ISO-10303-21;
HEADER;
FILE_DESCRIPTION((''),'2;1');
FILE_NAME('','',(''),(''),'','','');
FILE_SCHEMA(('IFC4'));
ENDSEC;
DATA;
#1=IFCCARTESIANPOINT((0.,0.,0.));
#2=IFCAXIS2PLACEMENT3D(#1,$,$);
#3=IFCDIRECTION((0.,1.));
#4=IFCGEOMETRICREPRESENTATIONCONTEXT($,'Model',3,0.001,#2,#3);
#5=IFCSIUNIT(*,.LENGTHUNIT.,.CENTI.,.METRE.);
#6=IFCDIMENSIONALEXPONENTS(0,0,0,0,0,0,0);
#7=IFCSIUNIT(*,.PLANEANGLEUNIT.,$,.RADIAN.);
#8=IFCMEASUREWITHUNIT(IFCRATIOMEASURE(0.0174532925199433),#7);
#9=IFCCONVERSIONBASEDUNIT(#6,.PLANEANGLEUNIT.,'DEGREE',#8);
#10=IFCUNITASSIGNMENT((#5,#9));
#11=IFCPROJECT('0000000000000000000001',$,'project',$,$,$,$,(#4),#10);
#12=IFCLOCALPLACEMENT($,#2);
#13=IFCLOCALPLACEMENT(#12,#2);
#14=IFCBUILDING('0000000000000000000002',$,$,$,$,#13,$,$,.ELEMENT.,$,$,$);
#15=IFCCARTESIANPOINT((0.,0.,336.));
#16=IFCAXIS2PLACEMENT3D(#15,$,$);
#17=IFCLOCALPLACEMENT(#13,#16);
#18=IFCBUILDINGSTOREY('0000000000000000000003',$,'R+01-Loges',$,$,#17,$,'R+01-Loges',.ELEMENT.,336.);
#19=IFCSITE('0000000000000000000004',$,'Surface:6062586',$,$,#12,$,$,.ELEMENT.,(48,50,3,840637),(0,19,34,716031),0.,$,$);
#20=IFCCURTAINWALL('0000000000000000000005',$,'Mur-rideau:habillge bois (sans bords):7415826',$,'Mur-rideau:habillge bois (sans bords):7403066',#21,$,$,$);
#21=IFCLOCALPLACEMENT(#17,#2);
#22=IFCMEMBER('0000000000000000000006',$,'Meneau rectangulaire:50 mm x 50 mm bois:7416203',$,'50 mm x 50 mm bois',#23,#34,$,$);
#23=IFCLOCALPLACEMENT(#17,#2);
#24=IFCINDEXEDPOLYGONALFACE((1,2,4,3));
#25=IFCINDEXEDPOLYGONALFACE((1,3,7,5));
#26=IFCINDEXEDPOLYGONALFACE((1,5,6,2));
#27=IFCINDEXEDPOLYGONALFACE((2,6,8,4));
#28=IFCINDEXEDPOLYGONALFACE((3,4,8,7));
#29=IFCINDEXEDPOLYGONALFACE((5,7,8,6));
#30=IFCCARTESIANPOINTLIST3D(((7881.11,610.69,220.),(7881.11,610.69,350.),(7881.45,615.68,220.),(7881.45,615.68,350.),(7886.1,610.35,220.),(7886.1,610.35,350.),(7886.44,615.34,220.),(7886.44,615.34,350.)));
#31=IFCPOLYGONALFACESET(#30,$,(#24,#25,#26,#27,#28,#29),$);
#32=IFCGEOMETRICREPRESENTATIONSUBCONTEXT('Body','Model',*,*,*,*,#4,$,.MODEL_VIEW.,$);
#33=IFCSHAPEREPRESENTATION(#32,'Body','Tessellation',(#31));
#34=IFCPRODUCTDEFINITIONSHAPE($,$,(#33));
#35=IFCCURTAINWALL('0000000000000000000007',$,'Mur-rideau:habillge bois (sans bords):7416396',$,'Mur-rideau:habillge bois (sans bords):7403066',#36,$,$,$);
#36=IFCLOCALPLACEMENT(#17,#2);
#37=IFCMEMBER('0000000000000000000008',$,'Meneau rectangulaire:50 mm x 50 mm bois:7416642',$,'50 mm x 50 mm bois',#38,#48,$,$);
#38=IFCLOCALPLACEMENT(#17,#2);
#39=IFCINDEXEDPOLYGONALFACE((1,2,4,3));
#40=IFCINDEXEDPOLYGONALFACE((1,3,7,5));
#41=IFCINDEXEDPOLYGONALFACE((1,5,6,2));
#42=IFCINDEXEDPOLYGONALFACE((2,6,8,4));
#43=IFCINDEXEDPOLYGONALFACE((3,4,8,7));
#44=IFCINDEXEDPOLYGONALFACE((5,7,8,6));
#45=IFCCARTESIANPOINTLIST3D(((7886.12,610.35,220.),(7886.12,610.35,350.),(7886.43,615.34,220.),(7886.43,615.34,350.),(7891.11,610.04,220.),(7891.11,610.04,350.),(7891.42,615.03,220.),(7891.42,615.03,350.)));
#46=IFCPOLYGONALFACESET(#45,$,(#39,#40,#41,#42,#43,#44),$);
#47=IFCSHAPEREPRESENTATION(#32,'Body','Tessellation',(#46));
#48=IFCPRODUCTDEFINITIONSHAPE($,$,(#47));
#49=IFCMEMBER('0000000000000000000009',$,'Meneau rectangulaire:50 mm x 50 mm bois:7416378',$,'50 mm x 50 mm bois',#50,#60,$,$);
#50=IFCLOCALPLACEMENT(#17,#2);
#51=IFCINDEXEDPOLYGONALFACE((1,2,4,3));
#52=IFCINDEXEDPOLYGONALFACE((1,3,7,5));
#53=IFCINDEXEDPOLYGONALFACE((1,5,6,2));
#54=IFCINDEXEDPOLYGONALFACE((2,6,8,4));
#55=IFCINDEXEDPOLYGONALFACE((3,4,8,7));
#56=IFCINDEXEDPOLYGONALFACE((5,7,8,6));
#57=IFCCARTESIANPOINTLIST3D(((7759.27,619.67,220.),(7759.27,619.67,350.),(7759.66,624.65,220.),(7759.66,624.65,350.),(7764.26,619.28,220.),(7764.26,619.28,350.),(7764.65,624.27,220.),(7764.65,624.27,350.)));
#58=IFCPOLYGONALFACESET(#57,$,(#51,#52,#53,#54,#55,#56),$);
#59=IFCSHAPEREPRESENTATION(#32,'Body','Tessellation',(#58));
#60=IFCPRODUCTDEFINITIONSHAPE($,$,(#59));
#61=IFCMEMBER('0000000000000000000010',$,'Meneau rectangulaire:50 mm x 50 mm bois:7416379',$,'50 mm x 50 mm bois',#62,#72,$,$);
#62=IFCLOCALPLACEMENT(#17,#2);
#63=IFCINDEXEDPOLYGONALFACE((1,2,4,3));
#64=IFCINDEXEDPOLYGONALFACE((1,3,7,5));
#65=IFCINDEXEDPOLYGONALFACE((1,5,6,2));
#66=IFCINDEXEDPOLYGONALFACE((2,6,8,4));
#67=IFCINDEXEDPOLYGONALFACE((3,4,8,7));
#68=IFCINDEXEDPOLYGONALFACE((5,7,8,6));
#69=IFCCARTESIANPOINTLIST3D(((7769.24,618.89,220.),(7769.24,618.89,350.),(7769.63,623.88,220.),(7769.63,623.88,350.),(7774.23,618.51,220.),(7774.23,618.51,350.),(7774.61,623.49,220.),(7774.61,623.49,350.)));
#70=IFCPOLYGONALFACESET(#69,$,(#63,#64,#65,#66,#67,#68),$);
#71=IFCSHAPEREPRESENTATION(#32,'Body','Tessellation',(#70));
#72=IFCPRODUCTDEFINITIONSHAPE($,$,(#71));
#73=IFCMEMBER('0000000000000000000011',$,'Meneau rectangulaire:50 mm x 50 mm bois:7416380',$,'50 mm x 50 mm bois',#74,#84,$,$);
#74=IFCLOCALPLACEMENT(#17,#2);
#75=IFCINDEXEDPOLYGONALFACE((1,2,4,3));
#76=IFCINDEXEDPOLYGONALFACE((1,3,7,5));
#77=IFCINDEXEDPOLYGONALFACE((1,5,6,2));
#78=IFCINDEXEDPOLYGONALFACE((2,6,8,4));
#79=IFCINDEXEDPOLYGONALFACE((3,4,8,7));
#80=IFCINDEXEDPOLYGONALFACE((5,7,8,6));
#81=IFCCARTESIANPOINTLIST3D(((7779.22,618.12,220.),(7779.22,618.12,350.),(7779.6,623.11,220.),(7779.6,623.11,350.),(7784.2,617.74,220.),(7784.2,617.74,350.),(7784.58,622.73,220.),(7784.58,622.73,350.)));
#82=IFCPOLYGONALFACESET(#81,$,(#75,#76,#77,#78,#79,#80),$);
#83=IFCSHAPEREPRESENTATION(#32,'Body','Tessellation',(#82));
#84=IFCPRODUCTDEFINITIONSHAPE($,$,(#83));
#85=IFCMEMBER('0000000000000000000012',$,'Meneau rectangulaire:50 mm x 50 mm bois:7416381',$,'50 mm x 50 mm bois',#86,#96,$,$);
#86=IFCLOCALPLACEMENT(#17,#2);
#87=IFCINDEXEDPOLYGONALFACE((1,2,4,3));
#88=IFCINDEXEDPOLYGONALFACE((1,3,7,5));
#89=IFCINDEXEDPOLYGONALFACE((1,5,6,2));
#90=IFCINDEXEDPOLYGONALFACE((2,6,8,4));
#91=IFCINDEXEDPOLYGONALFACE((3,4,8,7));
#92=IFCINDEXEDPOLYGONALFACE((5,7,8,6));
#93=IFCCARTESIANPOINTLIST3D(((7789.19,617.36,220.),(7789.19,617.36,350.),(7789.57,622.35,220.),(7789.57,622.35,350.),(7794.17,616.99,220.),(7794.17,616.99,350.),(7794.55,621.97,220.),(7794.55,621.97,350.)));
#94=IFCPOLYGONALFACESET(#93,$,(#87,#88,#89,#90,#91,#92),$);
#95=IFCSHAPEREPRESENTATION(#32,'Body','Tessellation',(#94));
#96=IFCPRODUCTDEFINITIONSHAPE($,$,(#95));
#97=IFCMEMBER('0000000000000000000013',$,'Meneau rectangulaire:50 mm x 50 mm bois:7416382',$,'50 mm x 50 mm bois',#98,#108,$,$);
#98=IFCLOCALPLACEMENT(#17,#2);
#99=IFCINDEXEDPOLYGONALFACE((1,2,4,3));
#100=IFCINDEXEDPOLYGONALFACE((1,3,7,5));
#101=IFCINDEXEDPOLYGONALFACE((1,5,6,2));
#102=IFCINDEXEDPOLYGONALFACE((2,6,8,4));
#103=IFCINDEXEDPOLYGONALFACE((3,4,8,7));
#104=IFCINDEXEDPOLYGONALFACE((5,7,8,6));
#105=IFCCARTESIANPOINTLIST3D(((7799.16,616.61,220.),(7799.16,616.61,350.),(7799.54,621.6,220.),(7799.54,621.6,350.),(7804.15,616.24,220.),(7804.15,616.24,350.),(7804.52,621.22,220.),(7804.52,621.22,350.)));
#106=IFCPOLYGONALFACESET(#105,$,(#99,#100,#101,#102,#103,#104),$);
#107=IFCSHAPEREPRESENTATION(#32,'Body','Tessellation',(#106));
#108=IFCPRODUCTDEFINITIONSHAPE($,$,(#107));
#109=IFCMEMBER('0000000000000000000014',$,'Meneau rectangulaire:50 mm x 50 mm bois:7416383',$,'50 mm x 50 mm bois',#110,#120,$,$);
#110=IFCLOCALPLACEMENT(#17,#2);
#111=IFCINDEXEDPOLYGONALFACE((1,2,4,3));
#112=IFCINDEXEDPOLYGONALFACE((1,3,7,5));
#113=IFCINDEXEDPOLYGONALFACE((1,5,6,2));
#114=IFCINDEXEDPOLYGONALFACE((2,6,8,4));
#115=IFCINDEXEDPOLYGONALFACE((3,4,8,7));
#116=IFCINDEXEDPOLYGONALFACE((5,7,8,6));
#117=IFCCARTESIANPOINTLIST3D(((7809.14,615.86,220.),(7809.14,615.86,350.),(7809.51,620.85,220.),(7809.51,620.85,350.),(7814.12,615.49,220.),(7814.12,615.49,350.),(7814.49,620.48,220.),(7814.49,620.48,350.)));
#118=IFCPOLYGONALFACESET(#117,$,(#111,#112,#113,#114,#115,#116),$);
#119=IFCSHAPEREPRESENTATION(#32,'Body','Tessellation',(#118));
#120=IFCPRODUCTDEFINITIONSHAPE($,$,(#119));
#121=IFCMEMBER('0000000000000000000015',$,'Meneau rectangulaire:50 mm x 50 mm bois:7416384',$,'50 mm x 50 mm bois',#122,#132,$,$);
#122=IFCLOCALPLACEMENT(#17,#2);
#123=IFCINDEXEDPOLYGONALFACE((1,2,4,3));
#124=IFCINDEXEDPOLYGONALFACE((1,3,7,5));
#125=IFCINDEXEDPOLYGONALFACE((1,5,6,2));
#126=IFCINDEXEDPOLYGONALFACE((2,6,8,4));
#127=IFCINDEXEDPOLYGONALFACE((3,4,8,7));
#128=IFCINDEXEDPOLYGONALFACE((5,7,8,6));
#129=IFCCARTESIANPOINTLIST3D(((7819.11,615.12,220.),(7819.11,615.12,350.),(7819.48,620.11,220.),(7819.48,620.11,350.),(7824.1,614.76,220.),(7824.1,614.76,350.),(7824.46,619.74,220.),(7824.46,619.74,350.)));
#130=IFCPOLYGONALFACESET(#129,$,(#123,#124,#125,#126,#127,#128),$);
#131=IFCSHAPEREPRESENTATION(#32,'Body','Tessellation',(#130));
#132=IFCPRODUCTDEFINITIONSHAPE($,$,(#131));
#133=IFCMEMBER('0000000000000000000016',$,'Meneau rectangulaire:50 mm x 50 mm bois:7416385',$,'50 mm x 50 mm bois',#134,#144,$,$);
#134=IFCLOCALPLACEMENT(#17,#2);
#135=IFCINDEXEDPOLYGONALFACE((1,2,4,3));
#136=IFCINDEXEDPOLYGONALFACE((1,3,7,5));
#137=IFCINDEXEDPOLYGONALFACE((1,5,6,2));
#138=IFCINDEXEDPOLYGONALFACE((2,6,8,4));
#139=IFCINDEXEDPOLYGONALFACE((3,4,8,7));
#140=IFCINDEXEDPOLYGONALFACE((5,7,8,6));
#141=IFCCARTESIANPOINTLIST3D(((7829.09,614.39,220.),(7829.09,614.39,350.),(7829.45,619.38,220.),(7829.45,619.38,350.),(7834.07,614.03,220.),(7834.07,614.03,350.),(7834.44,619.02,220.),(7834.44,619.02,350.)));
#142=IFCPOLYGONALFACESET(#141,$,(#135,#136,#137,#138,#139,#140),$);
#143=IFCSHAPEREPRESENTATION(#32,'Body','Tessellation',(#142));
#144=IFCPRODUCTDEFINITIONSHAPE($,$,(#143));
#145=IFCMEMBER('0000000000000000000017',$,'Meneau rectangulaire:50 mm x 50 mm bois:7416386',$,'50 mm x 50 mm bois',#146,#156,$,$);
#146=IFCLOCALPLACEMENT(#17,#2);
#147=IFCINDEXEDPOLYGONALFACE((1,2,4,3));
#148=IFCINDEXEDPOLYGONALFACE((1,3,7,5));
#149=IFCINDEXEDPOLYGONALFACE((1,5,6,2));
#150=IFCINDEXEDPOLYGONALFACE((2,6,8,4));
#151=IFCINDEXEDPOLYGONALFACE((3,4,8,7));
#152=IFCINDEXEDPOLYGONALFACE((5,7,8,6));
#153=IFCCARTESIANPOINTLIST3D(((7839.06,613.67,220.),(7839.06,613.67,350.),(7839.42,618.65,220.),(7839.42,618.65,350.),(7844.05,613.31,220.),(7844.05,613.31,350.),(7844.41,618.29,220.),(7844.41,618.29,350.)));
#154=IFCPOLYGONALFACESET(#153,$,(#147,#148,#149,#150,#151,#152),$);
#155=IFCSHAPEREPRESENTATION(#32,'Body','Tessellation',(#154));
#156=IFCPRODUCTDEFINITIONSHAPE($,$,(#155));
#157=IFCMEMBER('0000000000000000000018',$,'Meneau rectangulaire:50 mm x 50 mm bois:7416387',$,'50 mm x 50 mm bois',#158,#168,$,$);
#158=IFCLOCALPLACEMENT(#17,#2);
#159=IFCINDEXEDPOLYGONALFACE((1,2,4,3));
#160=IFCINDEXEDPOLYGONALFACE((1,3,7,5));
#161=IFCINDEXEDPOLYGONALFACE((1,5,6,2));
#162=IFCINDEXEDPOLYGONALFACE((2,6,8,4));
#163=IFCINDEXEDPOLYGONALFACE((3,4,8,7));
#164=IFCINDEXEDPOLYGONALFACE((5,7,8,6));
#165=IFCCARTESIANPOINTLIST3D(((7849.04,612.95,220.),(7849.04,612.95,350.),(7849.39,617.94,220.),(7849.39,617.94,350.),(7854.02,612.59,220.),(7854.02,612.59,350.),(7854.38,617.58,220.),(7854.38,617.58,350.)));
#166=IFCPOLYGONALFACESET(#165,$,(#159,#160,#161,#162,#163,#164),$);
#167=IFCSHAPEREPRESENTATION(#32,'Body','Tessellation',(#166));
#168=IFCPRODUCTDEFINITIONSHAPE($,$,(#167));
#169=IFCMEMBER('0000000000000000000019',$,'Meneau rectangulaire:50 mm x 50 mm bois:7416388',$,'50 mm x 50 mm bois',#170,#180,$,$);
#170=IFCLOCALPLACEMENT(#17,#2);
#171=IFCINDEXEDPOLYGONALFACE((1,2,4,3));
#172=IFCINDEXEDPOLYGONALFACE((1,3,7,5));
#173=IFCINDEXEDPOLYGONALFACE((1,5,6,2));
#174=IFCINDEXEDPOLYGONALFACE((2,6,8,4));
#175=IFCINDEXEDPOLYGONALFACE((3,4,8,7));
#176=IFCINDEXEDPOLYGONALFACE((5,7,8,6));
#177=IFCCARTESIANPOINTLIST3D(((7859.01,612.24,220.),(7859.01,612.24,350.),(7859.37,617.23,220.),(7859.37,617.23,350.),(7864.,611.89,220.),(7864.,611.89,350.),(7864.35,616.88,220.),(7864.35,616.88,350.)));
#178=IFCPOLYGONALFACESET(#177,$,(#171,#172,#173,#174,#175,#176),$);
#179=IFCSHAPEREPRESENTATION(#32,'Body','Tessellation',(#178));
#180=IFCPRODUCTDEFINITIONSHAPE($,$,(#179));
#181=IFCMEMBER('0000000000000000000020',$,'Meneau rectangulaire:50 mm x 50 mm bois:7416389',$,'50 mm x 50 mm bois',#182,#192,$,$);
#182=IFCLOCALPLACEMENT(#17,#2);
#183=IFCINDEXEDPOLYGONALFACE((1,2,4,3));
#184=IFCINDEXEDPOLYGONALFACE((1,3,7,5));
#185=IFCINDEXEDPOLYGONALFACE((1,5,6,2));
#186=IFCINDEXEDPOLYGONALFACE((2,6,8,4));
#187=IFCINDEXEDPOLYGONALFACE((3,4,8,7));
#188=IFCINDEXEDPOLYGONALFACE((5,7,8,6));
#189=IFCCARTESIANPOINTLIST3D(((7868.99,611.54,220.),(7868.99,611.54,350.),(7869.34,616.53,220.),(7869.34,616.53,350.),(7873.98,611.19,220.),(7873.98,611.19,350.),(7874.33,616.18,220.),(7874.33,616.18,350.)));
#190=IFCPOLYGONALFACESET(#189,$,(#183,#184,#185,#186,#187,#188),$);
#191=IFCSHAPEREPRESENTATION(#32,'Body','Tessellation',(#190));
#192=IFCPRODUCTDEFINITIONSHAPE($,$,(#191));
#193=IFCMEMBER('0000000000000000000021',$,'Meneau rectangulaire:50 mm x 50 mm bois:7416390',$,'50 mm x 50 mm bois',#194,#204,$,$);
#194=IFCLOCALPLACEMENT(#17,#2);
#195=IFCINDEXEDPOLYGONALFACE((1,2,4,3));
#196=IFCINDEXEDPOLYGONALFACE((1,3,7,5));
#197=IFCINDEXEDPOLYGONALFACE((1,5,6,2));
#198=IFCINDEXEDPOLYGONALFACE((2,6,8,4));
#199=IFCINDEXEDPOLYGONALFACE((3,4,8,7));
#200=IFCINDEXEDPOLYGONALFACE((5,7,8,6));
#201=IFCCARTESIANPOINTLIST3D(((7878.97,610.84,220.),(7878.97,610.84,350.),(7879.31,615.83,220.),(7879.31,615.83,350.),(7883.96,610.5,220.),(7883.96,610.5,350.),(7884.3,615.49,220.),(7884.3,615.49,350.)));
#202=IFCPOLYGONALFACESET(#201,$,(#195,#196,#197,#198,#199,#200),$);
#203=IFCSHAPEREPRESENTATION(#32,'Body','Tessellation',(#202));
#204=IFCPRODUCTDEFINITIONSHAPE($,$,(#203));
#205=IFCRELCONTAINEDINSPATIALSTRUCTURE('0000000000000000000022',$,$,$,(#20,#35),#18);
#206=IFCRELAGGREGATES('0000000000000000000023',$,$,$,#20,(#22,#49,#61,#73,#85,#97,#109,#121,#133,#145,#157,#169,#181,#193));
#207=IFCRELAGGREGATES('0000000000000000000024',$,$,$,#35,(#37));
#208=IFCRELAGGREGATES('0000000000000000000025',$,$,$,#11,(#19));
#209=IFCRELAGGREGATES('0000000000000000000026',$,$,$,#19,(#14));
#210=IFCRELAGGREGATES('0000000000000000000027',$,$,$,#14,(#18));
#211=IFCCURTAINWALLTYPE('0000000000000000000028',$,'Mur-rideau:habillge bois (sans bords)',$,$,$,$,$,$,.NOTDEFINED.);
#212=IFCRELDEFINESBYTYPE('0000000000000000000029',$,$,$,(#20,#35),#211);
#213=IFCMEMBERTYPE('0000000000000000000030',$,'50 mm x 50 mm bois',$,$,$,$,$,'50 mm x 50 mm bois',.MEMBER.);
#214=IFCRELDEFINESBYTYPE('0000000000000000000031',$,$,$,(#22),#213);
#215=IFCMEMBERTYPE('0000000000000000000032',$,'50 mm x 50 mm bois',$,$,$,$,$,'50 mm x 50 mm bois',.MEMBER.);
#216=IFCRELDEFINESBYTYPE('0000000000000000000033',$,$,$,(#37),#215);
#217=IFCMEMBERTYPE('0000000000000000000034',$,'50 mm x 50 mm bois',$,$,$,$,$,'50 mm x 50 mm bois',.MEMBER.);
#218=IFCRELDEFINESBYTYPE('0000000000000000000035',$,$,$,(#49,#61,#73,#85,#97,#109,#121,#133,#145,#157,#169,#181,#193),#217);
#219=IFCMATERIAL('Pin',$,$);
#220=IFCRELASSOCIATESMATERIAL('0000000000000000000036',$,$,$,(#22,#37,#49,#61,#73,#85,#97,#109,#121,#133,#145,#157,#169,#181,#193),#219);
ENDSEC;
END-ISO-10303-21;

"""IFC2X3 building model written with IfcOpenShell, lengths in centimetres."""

from ifc_helpers import new_model, entity, si_unit, converted_unit, direction, frame, origin, origin_2d_with_axis, place, context, subcontext, project, spatial, rectangle, extrude, source, transform, mapped, material, type_object, type_shapes, element, aggregate, save


model = new_model("IFC2X3")

# Units and contexts
model_context = context("Model", 3, precision=0.001, world=origin(), true_north=direction((0.0, 1.0)))
body_context = subcontext(model_context, "Body", "Model", "MODEL_VIEW")
ifc_project = project(units=[si_unit("LENGTHUNIT", "METRE", prefix="CENTI"), converted_unit("PLANEANGLEUNIT", "DEGREE", entity("IfcRatioMeasure", 0.0174532925199433), si_unit("PLANEANGLEUNIT", "RADIAN"), dimensions=[0, 0, 0, 0, 0, 0, 0])], contexts=[model_context])

# Site, building, storey
site_placement = place(None, origin())
site = spatial("IfcSite", under=ifc_project, at=site_placement, Name="Surface:6062586", CompositionType="ELEMENT", RefLatitude=(48, 50, 3, 840637), RefLongitude=(0, 19, 34, 716031), RefElevation=0.0)
building_placement = place(site_placement, origin())
building = spatial("IfcBuilding", under=site, at=building_placement, CompositionType="ELEMENT")
storey_placement = place(building_placement, frame((0.0, 0.0, 336.0)))
storey = spatial("IfcBuildingStorey", under=building, at=storey_placement, Name="R+01-Loges", LongName="R+01-Loges", CompositionType="ELEMENT", Elevation=336.0)

# Curtain walls, members
curtain_wall_type = type_object("IfcCurtainWallType", Name="Mur-rideau:habillge bois (sans bords)", PredefinedType="NOTDEFINED")
curtain_wall_1_placement = place(storey_placement, frame((0.0, 0.0, -336.0)))
curtain_wall_1 = element("IfcCurtainWall", 1, at=curtain_wall_1_placement, inside=storey, type_object=curtain_wall_type, Name="Mur-rideau:habillge bois (sans bords):7415826", ObjectType="Mur-rideau:habillge bois (sans bords):7403066")
ifc_material_1 = material(Name="Pin")
member_type_1 = type_object("IfcMemberType", Name="50 mm x 50 mm bois", ElementType="50 mm x 50 mm bois", PredefinedType="MEMBER")
shared_shape_1 = source(origin(), body_context, "Body", "SweptSolid", [
    extrude(rectangle(XDim=5.0, YDim=5.0, at=origin_2d_with_axis()), frame((-2.5, 0.0, -130.0), z_axis=(0.0, 0.0, 1.0), x_axis=(0.0, -1.0, 0.0)), (0.0, 0.0, 1.0), 130.0),
])
type_shapes(member_type_1, [shared_shape_1])
member_1_placement = place(storey_placement, frame((7886.27, 612.84, 220.0), z_axis=(0.0, 0.0, -1.0), x_axis=(0.997631, -0.068788, 0.0)))
member_1 = element("IfcMember", 2, at=member_1_placement, type_object=member_type_1, material=ifc_material_1, Name="Meneau rectangulaire:50 mm x 50 mm bois:7416203", ObjectType="50 mm x 50 mm bois", context=body_context, shape_type="MappedRepresentation", body=[
    mapped(shared_shape_1, transform((0.0, 0.0, 0.0), scale=1.0)),
])
curtain_wall_2_placement = place(storey_placement, frame((0.0, 0.0, -336.0)))
curtain_wall_2 = element("IfcCurtainWall", 3, at=curtain_wall_2_placement, inside=storey, type_object=curtain_wall_type, Name="Mur-rideau:habillge bois (sans bords):7416396", ObjectType="Mur-rideau:habillge bois (sans bords):7403066")
member_type_2 = type_object("IfcMemberType", Name="50 mm x 50 mm bois", ElementType="50 mm x 50 mm bois", PredefinedType="MEMBER")
shared_shape_2 = source(origin(), body_context, "Body", "SweptSolid", [
    extrude(rectangle(XDim=5.0, YDim=5.0, at=origin_2d_with_axis()), frame((-2.5, 0.0, -130.0), z_axis=(0.0, 0.0, 1.0), x_axis=(0.0, -1.0, 0.0)), (0.0, 0.0, 1.0), 130.0),
])
type_shapes(member_type_2, [shared_shape_2])
member_2_placement = place(storey_placement, frame((7886.27, 612.84, 350.0), z_axis=(0.0, 0.0, 1.0), x_axis=(-0.998061, 0.062237, 0.0)))
member_2 = element("IfcMember", 4, at=member_2_placement, type_object=member_type_2, material=ifc_material_1, Name="Meneau rectangulaire:50 mm x 50 mm bois:7416642", ObjectType="50 mm x 50 mm bois", context=body_context, shape_type="MappedRepresentation", body=[
    mapped(shared_shape_2, transform((0.0, 0.0, 0.0), scale=1.0)),
])

# Members
member_type_3 = type_object("IfcMemberType", Name="50 mm x 50 mm bois", ElementType="50 mm x 50 mm bois", PredefinedType="MEMBER")
shared_shape_3 = source(origin(), body_context, "Body", "SweptSolid", [
    extrude(rectangle(XDim=5.0, YDim=5.0, at=origin_2d_with_axis()), frame((0.0, 0.0, -130.0), z_axis=(0.0, 0.0, 1.0), x_axis=(0.0, -1.0, 0.0)), (0.0, 0.0, 1.0), 130.0),
])
type_shapes(member_type_3, [shared_shape_3])
member_3_placement = place(storey_placement, frame((7761.96, 621.97, 220.0), z_axis=(0.0, 0.0, -1.0), x_axis=(0.996972, -0.077764, 0.0)))
member_3 = element("IfcMember", 5, at=member_3_placement, type_object=member_type_3, material=ifc_material_1, Name="Meneau rectangulaire:50 mm x 50 mm bois:7416378", ObjectType="50 mm x 50 mm bois", context=body_context, shape_type="MappedRepresentation", body=[
    mapped(shared_shape_3, transform((0.0, 0.0, 0.0), scale=1.0)),
])
member_4_placement = place(storey_placement, frame((7771.93, 621.19, 220.0), z_axis=(0.0, 0.0, -1.0), x_axis=(0.997029, -0.077031, 0.0)))
member_4 = element("IfcMember", 6, at=member_4_placement, type_object=member_type_3, material=ifc_material_1, Name="Meneau rectangulaire:50 mm x 50 mm bois:7416379", ObjectType="50 mm x 50 mm bois", context=body_context, shape_type="MappedRepresentation", body=[
    mapped(shared_shape_3, transform((0.0, 0.0, 0.0), scale=1.0)),
])
member_5_placement = place(storey_placement, frame((7781.9, 620.43, 220.0), z_axis=(0.0, 0.0, -1.0), x_axis=(0.997085, -0.076297, 0.0)))
member_5 = element("IfcMember", 7, at=member_5_placement, type_object=member_type_3, material=ifc_material_1, Name="Meneau rectangulaire:50 mm x 50 mm bois:7416380", ObjectType="50 mm x 50 mm bois", context=body_context, shape_type="MappedRepresentation", body=[
    mapped(shared_shape_3, transform((0.0, 0.0, 0.0), scale=1.0)),
])
member_6_placement = place(storey_placement, frame((7791.87, 619.67, 220.0), z_axis=(0.0, 0.0, -1.0), x_axis=(0.997141, -0.075564, 0.0)))
member_6 = element("IfcMember", 8, at=member_6_placement, type_object=member_type_3, material=ifc_material_1, Name="Meneau rectangulaire:50 mm x 50 mm bois:7416381", ObjectType="50 mm x 50 mm bois", context=body_context, shape_type="MappedRepresentation", body=[
    mapped(shared_shape_3, transform((0.0, 0.0, 0.0), scale=1.0)),
])
member_7_placement = place(storey_placement, frame((7801.84, 618.92, 220.0), z_axis=(0.0, 0.0, -1.0), x_axis=(0.997196, -0.07483, 0.0)))
member_7 = element("IfcMember", 9, at=member_7_placement, type_object=member_type_3, material=ifc_material_1, Name="Meneau rectangulaire:50 mm x 50 mm bois:7416382", ObjectType="50 mm x 50 mm bois", context=body_context, shape_type="MappedRepresentation", body=[
    mapped(shared_shape_3, transform((0.0, 0.0, 0.0), scale=1.0)),
])
member_8_placement = place(storey_placement, frame((7811.81, 618.17, 220.0), z_axis=(0.0, 0.0, -1.0), x_axis=(0.997251, -0.074096, 0.0)))
member_8 = element("IfcMember", 10, at=member_8_placement, type_object=member_type_3, material=ifc_material_1, Name="Meneau rectangulaire:50 mm x 50 mm bois:7416383", ObjectType="50 mm x 50 mm bois", context=body_context, shape_type="MappedRepresentation", body=[
    mapped(shared_shape_3, transform((0.0, 0.0, 0.0), scale=1.0)),
])
member_9_placement = place(storey_placement, frame((7821.79, 617.43, 220.0), z_axis=(0.0, 0.0, -1.0), x_axis=(0.997305, -0.073362, 0.0)))
member_9 = element("IfcMember", 11, at=member_9_placement, type_object=member_type_3, material=ifc_material_1, Name="Meneau rectangulaire:50 mm x 50 mm bois:7416384", ObjectType="50 mm x 50 mm bois", context=body_context, shape_type="MappedRepresentation", body=[
    mapped(shared_shape_3, transform((0.0, 0.0, 0.0), scale=1.0)),
])
member_10_placement = place(storey_placement, frame((7831.76, 616.7, 220.0), z_axis=(0.0, 0.0, -1.0), x_axis=(0.997359, -0.072628, 0.0)))
member_10 = element("IfcMember", 12, at=member_10_placement, type_object=member_type_3, material=ifc_material_1, Name="Meneau rectangulaire:50 mm x 50 mm bois:7416385", ObjectType="50 mm x 50 mm bois", context=body_context, shape_type="MappedRepresentation", body=[
    mapped(shared_shape_3, transform((0.0, 0.0, 0.0), scale=1.0)),
])
member_11_placement = place(storey_placement, frame((7841.73, 615.98, 220.0), z_axis=(0.0, 0.0, -1.0), x_axis=(0.997412, -0.071895, 0.0)))
member_11 = element("IfcMember", 13, at=member_11_placement, type_object=member_type_3, material=ifc_material_1, Name="Meneau rectangulaire:50 mm x 50 mm bois:7416386", ObjectType="50 mm x 50 mm bois", context=body_context, shape_type="MappedRepresentation", body=[
    mapped(shared_shape_3, transform((0.0, 0.0, 0.0), scale=1.0)),
])
member_12_placement = place(storey_placement, frame((7851.71, 615.27, 220.0), z_axis=(0.0, 0.0, -1.0), x_axis=(0.997465, -0.071161, 0.0)))
member_12 = element("IfcMember", 14, at=member_12_placement, type_object=member_type_3, material=ifc_material_1, Name="Meneau rectangulaire:50 mm x 50 mm bois:7416387", ObjectType="50 mm x 50 mm bois", context=body_context, shape_type="MappedRepresentation", body=[
    mapped(shared_shape_3, transform((0.0, 0.0, 0.0), scale=1.0)),
])
member_13_placement = place(storey_placement, frame((7861.68, 614.56, 220.0), z_axis=(0.0, 0.0, -1.0), x_axis=(0.997517, -0.070427, 0.0)))
member_13 = element("IfcMember", 15, at=member_13_placement, type_object=member_type_3, material=ifc_material_1, Name="Meneau rectangulaire:50 mm x 50 mm bois:7416388", ObjectType="50 mm x 50 mm bois", context=body_context, shape_type="MappedRepresentation", body=[
    mapped(shared_shape_3, transform((0.0, 0.0, 0.0), scale=1.0)),
])
member_14_placement = place(storey_placement, frame((7871.66, 613.86, 220.0), z_axis=(0.0, 0.0, -1.0), x_axis=(0.997569, -0.069693, 0.0)))
member_14 = element("IfcMember", 16, at=member_14_placement, type_object=member_type_3, material=ifc_material_1, Name="Meneau rectangulaire:50 mm x 50 mm bois:7416389", ObjectType="50 mm x 50 mm bois", context=body_context, shape_type="MappedRepresentation", body=[
    mapped(shared_shape_3, transform((0.0, 0.0, 0.0), scale=1.0)),
])
member_15_placement = place(storey_placement, frame((7881.63, 613.16, 220.0), z_axis=(0.0, 0.0, -1.0), x_axis=(0.99762, -0.068959, 0.0)))
member_15 = element("IfcMember", 17, at=member_15_placement, type_object=member_type_3, material=ifc_material_1, Name="Meneau rectangulaire:50 mm x 50 mm bois:7416390", ObjectType="50 mm x 50 mm bois", context=body_context, shape_type="MappedRepresentation", body=[
    mapped(shared_shape_3, transform((0.0, 0.0, 0.0), scale=1.0)),
])
aggregate(curtain_wall_1, [member_1, member_3, member_4, member_5, member_6, member_7, member_8, member_9, member_10, member_11, member_12, member_13, member_14, member_15])
aggregate(curtain_wall_2, [member_2])

save(model, "model.ifc")
